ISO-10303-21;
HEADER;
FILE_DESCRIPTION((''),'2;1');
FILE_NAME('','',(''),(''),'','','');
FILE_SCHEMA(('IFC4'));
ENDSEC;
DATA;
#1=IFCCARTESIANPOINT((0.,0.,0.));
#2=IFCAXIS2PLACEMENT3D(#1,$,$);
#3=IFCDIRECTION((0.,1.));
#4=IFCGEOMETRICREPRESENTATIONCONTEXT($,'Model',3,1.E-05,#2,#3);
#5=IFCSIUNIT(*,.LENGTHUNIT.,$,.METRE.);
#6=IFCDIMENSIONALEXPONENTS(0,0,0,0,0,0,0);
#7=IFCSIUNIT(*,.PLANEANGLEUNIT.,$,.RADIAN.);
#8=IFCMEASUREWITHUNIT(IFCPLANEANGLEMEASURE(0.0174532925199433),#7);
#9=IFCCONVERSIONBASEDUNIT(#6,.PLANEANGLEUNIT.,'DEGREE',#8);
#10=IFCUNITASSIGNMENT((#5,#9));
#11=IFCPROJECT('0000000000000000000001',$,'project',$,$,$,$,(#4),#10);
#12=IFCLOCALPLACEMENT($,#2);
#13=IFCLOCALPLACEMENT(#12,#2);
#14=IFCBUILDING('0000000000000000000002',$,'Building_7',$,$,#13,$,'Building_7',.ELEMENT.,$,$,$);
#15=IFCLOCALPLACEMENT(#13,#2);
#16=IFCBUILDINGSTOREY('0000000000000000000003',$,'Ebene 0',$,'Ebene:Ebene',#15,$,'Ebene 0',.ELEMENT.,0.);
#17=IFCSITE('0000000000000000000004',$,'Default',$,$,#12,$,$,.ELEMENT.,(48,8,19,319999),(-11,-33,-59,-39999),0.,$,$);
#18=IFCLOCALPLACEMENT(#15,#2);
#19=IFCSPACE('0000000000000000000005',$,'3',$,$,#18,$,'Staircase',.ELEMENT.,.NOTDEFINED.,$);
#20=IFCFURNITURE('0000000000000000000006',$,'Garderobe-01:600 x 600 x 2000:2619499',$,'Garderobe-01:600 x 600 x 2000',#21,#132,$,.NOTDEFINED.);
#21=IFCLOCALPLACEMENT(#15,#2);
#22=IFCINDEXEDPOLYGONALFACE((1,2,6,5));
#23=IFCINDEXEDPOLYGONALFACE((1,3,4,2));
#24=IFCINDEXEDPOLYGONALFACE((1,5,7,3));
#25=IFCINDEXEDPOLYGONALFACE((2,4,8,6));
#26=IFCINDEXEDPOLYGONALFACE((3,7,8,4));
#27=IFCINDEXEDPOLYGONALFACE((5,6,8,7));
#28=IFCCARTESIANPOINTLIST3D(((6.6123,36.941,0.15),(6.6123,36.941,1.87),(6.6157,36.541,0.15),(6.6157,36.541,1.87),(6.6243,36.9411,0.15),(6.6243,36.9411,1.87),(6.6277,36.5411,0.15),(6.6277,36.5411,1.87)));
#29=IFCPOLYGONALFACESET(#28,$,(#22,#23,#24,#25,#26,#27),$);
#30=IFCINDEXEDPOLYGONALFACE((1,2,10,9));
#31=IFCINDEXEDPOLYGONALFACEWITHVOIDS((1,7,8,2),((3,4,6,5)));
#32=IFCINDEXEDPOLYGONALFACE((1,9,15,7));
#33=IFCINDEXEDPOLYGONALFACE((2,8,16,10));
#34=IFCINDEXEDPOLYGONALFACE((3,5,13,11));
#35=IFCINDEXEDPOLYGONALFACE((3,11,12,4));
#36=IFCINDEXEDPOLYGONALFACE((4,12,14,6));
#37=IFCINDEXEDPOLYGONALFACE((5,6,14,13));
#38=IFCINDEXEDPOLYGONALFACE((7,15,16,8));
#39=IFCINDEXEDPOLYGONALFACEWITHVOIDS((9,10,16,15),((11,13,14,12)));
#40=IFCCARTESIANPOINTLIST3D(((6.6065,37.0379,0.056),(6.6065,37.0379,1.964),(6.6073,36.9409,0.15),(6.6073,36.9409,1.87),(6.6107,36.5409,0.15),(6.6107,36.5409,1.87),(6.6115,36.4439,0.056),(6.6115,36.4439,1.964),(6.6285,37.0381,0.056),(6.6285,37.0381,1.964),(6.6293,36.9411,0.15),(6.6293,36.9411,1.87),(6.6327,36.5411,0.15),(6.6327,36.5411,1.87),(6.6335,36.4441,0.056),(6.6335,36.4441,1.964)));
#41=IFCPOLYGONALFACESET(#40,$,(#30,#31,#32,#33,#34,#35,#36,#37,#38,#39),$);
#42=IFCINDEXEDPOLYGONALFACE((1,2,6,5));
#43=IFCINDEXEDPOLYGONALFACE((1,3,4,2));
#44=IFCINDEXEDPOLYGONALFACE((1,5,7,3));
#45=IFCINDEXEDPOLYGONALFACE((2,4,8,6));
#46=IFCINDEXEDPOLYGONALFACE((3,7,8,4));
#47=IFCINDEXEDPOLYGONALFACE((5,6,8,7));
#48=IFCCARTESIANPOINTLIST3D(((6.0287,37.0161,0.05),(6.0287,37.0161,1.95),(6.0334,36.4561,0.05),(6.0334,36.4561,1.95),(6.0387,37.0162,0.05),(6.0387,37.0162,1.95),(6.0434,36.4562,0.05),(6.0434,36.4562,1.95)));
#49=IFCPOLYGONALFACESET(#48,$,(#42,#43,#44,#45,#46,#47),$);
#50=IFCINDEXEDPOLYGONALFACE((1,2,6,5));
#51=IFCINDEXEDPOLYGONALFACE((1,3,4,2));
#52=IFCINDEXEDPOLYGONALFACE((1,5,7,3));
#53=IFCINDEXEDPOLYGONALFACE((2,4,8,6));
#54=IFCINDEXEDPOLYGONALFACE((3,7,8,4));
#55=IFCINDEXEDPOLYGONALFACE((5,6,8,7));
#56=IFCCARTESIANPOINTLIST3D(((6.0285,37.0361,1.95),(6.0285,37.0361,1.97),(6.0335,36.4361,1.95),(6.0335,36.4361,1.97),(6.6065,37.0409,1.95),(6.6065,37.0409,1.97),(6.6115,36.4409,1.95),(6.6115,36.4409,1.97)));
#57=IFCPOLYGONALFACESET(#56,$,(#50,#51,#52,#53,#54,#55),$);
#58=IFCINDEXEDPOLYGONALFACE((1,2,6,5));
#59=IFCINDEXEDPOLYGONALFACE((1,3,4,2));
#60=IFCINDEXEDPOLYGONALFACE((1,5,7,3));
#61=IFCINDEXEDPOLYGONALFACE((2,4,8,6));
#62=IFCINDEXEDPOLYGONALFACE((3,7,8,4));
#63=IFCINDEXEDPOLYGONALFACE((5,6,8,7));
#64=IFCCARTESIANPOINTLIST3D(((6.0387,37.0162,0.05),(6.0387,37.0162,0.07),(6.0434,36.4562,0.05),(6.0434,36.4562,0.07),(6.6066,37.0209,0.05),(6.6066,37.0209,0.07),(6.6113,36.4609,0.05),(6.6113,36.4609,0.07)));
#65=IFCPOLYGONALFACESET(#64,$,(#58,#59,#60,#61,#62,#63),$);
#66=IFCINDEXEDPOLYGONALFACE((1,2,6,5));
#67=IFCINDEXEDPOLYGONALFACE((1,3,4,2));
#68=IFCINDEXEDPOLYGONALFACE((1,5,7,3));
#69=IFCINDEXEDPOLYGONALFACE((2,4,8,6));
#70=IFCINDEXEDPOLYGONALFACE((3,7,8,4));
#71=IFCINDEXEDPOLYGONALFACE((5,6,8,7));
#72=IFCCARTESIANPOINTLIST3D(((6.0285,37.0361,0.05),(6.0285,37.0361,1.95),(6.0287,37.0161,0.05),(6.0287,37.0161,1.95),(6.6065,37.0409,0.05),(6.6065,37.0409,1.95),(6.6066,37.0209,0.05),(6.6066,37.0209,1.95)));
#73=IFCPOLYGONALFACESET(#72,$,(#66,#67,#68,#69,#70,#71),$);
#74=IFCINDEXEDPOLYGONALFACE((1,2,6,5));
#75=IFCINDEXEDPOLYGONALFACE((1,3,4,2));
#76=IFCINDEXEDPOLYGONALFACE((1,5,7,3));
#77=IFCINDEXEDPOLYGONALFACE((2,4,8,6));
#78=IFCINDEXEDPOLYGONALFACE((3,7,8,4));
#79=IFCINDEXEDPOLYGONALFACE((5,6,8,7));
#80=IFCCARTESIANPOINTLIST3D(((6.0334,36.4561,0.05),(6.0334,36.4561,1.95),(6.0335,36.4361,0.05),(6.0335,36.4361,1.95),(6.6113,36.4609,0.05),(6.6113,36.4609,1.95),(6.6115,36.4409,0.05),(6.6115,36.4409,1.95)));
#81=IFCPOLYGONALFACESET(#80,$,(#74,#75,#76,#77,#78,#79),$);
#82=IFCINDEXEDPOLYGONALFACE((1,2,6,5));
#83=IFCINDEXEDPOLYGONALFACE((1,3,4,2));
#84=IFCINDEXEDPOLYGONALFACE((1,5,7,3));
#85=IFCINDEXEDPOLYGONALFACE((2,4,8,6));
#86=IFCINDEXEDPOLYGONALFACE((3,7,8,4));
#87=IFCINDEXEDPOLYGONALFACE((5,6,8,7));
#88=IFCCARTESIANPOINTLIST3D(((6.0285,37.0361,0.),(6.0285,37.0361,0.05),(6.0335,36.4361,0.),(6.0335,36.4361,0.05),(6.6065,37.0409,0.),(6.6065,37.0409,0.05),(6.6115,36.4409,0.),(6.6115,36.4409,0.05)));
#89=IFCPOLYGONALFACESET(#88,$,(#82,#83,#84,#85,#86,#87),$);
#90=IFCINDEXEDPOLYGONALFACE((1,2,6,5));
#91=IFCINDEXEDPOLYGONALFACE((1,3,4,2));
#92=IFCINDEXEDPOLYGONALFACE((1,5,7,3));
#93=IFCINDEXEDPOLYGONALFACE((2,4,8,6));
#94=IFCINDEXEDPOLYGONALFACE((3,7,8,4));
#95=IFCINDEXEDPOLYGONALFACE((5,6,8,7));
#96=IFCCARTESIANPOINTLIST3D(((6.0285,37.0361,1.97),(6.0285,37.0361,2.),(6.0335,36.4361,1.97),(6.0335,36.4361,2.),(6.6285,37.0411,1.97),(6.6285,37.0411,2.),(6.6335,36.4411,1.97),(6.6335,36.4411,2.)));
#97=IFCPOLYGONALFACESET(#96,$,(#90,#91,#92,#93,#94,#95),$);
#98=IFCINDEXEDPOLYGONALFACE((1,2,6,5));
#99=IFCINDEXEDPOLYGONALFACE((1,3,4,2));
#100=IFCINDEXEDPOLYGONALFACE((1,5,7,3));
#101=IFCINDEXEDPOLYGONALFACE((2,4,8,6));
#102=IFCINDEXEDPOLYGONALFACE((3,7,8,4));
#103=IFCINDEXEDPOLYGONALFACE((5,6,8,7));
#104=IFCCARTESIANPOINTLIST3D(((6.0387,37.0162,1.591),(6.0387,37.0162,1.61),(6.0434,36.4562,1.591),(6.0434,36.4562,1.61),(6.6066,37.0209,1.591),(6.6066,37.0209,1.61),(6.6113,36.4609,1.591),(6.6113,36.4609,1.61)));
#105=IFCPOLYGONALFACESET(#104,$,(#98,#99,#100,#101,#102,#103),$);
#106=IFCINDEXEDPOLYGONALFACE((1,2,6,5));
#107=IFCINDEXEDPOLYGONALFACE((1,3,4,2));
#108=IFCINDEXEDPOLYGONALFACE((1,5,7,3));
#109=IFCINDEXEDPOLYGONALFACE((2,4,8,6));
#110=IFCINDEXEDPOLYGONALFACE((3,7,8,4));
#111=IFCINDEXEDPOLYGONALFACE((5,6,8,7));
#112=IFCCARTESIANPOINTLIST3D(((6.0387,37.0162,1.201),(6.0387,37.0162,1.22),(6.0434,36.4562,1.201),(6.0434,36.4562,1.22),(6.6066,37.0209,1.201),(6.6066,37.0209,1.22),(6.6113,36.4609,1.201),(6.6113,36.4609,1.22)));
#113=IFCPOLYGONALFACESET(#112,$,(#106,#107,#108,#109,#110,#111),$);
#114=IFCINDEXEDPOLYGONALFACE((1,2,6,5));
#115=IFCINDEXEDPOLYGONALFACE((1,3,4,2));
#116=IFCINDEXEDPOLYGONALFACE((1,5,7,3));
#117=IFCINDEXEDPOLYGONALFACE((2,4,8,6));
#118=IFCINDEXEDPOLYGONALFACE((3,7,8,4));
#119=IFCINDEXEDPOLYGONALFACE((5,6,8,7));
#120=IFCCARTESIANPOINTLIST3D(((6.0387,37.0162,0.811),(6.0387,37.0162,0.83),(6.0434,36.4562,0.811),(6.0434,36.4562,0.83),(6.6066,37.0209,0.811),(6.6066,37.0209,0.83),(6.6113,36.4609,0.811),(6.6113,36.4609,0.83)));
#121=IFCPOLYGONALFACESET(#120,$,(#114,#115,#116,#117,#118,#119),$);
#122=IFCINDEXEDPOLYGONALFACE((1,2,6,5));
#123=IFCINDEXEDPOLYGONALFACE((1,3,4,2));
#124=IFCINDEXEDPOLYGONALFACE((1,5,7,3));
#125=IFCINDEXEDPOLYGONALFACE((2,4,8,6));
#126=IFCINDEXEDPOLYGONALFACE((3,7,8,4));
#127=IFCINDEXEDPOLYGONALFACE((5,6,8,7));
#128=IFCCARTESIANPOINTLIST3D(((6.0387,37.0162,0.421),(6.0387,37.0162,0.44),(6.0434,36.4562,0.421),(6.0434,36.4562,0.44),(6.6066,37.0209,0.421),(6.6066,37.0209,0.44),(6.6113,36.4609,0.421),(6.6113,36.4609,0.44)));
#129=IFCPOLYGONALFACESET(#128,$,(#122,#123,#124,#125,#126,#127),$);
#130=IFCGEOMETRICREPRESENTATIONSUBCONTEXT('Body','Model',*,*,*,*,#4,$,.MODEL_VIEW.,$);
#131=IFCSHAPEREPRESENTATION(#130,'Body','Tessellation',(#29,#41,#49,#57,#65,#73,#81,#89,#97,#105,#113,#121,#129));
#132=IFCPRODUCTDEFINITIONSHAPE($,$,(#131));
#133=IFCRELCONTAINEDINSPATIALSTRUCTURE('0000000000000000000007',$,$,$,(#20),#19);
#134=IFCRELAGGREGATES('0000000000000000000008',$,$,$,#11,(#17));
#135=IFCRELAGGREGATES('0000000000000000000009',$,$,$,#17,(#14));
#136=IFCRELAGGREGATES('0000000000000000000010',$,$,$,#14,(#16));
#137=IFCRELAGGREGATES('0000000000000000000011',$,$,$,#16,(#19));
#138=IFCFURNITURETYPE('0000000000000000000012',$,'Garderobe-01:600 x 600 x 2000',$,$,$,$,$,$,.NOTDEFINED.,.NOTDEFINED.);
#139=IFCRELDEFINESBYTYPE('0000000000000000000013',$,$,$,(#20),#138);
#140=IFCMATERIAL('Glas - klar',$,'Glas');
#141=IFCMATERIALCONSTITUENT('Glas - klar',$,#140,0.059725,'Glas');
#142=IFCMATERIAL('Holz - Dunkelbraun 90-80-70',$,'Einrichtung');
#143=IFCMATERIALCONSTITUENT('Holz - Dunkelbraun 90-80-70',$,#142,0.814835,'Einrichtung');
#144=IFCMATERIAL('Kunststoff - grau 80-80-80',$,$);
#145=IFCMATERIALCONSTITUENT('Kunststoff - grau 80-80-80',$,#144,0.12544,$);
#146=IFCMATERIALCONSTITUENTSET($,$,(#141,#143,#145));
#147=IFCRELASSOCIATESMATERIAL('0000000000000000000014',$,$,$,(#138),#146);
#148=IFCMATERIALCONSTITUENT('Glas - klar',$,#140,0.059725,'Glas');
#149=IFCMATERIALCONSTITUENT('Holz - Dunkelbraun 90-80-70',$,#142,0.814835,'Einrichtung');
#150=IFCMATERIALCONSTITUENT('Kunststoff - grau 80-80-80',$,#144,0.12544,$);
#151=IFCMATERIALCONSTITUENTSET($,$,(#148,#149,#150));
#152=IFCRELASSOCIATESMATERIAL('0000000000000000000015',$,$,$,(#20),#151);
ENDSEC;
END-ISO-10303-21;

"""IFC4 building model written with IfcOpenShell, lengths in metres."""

from ifc_helpers import new_model, entity, si_unit, converted_unit, direction, frame, origin, place, context, subcontext, project, spatial, indexed_curve, outline, extrude, source, transform, mapped, material, constituent, constituent_set, type_object, type_shapes, element, save


model = new_model("IFC4")

# Units and contexts
model_context = context("Model", 3, precision=1e-05, world=origin(), true_north=direction((0.0, 1.0)))
body_context = subcontext(model_context, "Body", "Model", "MODEL_VIEW")
ifc_project = project(units=[si_unit("LENGTHUNIT", "METRE"), converted_unit("PLANEANGLEUNIT", "DEGREE", entity("IfcPlaneAngleMeasure", 0.0174532925199433), si_unit("PLANEANGLEUNIT", "RADIAN"), dimensions=[0, 0, 0, 0, 0, 0, 0])], contexts=[model_context])

# Site, building, storey
site_placement = place(None, origin())
site = spatial("IfcSite", under=ifc_project, at=site_placement, Name="Default", CompositionType="ELEMENT", RefLatitude=(48, 8, 19, 319999), RefLongitude=(-11, -33, -59, -39999), RefElevation=0.0)
building_placement = place(site_placement, origin())
building = spatial("IfcBuilding", under=site, at=building_placement, Name="Building_7", LongName="Building_7", CompositionType="ELEMENT")
storey_placement = place(building_placement, origin())
storey = spatial("IfcBuildingStorey", under=building, at=storey_placement, Name="Ebene 0", ObjectType="Ebene:Ebene", LongName="Ebene 0", CompositionType="ELEMENT", Elevation=0.0)

# Shared definitions
ifc_material_1 = material(Name="Glas - klar", Category="Glas")
ifc_material_2 = material(Name="Holz - Dunkelbraun 90-80-70", Category="Einrichtung")
ifc_material_3 = material(Name="Kunststoff - grau 80-80-80")
ifc_constituent_1 = constituent(ifc_material_1, Name="Glas - klar", Category="Glas", fraction=0.059725)
ifc_constituent_2 = constituent(ifc_material_2, Name="Holz - Dunkelbraun 90-80-70", Category="Einrichtung", fraction=0.814835)
ifc_constituent_3 = constituent(ifc_material_3, Name="Kunststoff - grau 80-80-80", fraction=0.12544)
ifc_constituent_set_1 = constituent_set(constituents=[ifc_constituent_1, ifc_constituent_2, ifc_constituent_3])
furniture_type_1 = type_object("IfcFurnitureType", Name="Garderobe-01:600 x 600 x 2000", AssemblyPlace="NOTDEFINED", PredefinedType="NOTDEFINED", material=ifc_constituent_set_1)
shared_shape_1 = source(origin(), body_context, "Body", "SweptSolid", [
    extrude(outline(indexed_curve([(-0.006, -0.2), (0.006, -0.2), (0.006, 0.2), (-0.006, 0.2), (-0.006, -0.2)], self_intersect=False)), frame((0.0, -0.289, 0.15), z_axis=(0.0, 0.0, 1.0), x_axis=(0.0, 1.0, 0.0)), (0.0, 0.0, 1.0), 1.72),
    extrude(outline(indexed_curve([(-0.954, -0.297), (0.954, -0.297), (0.954, 0.297), (-0.954, 0.297), (-0.954, -0.297)], self_intersect=False), holes=[indexed_curve([(-0.86, 0.2), (0.86, 0.2), (0.86, -0.2), (-0.86, -0.2), (-0.86, 0.2)], self_intersect=False)]), frame((0.0, -0.3, 1.01), z_axis=(0.0, 1.0, 0.0), x_axis=(0.0, 0.0, -1.0)), (0.0, 0.0, 1.0), 0.022),
    extrude(outline(indexed_curve([(-0.28, -0.005), (0.28, -0.005), (0.28, 0.005), (-0.28, 0.005), (-0.28, -0.005)], self_intersect=False)), frame((0.0, 0.295, 0.05), z_axis=(0.0, 0.0, 1.0), x_axis=(-1.0, 0.0, 0.0)), (0.0, 0.0, 1.0), 1.9),
    extrude(outline(indexed_curve([(-0.3, -0.289), (0.3, -0.289), (0.3, 0.289), (-0.3, 0.289), (-0.3, -0.289)], self_intersect=False)), frame((0.0, 0.011, 1.95), z_axis=(0.0, 0.0, 1.0), x_axis=(-1.0, 0.0, 0.0)), (0.0, 0.0, 1.0), 0.02),
    extrude(outline(indexed_curve([(-0.28, -0.284), (0.28, -0.284), (0.28, 0.284), (-0.28, 0.284), (-0.28, -0.284)], self_intersect=False)), frame((0.0, 0.006, 0.05), z_axis=(0.0, 0.0, 1.0), x_axis=(-1.0, 0.0, 0.0)), (0.0, 0.0, 1.0), 0.02),
    extrude(outline(indexed_curve([(-0.01, -0.289), (0.01, -0.289), (0.01, 0.289), (-0.01, 0.289), (-0.01, -0.289)], self_intersect=False)), frame((0.29, 0.011, 0.05), z_axis=(0.0, 0.0, 1.0), x_axis=(-1.0, 0.0, 0.0)), (0.0, 0.0, 1.0), 1.9),
    extrude(outline(indexed_curve([(-0.01, -0.289), (0.01, -0.289), (0.01, 0.289), (-0.01, 0.289), (-0.01, -0.289)], self_intersect=False)), frame((-0.29, 0.011, 0.05), z_axis=(0.0, 0.0, 1.0), x_axis=(-1.0, 0.0, 0.0)), (0.0, 0.0, 1.0), 1.9),
    extrude(outline(indexed_curve([(-0.3, -0.289), (0.3, -0.289), (0.3, 0.289), (-0.3, 0.289), (-0.3, -0.289)], self_intersect=False)), frame((0.0, 0.011, 0.0), z_axis=(0.0, 0.0, 1.0), x_axis=(-1.0, 0.0, 0.0)), (0.0, 0.0, 1.0), 0.05),
    extrude(outline(indexed_curve([(-0.3, -0.3), (0.3, -0.3), (0.3, 0.3), (-0.3, 0.3), (-0.3, -0.3)], self_intersect=False)), frame((0.0, 0.0, 1.97), z_axis=(0.0, 0.0, 1.0), x_axis=(-1.0, 0.0, 0.0)), (0.0, 0.0, 1.0), 0.03),
    extrude(outline(indexed_curve([(-0.28, -0.284), (0.28, -0.284), (0.28, 0.284), (-0.28, 0.284), (-0.28, -0.284)], self_intersect=False)), frame((0.0, 0.006, 1.591), z_axis=(0.0, 0.0, 1.0), x_axis=(-1.0, 0.0, 0.0)), (0.0, 0.0, 1.0), 0.019),
    extrude(outline(indexed_curve([(-0.28, -0.284), (0.28, -0.284), (0.28, 0.284), (-0.28, 0.284), (-0.28, -0.284)], self_intersect=False)), frame((0.0, 0.006, 1.201), z_axis=(0.0, 0.0, 1.0), x_axis=(-1.0, 0.0, 0.0)), (0.0, 0.0, 1.0), 0.019),
    extrude(outline(indexed_curve([(-0.28, -0.284), (0.28, -0.284), (0.28, 0.284), (-0.28, 0.284), (-0.28, -0.284)], self_intersect=False)), frame((0.0, 0.006, 0.811), z_axis=(0.0, 0.0, 1.0), x_axis=(-1.0, 0.0, 0.0)), (0.0, 0.0, 1.0), 0.019),
    extrude(outline(indexed_curve([(-0.28, -0.284), (0.28, -0.284), (0.28, 0.284), (-0.28, 0.284), (-0.28, -0.284)], self_intersect=False)), frame((0.0, 0.006, 0.421), z_axis=(0.0, 0.0, 1.0), x_axis=(-1.0, 0.0, 0.0)), (0.0, 0.0, 1.0), 0.019),
])
type_shapes(furniture_type_1, [shared_shape_1])

# Shared definitions
space_1_placement = place(storey_placement, origin())
space_1 = spatial("IfcSpace", under=storey, at=space_1_placement, Name="3", LongName="Staircase", CompositionType="ELEMENT", PredefinedType="NOTDEFINED")

# Furniture
ifc_constituent_4 = constituent(ifc_material_1, Name="Glas - klar", Category="Glas", fraction=0.059725)
ifc_constituent_5 = constituent(ifc_material_2, Name="Holz - Dunkelbraun 90-80-70", Category="Einrichtung", fraction=0.814835)
ifc_constituent_6 = constituent(ifc_material_3, Name="Kunststoff - grau 80-80-80", fraction=0.12544)
ifc_constituent_set_2 = constituent_set(constituents=[ifc_constituent_4, ifc_constituent_5, ifc_constituent_6])
furniture_1_placement = place(space_1_placement, frame((6.331, 36.7386, 0.0), z_axis=(0.0, 0.0, 1.0), x_axis=(-0.008366, 0.999965, 0.0)))
element("IfcFurniture", 1, at=furniture_1_placement, inside=space_1, type_object=furniture_type_1, material=ifc_constituent_set_2, Name="Garderobe-01:600 x 600 x 2000:2619499", ObjectType="Garderobe-01:600 x 600 x 2000", PredefinedType="NOTDEFINED", context=body_context, shape_type="MappedRepresentation", body=[
    mapped(shared_shape_1, transform((0.0, 0.0, 0.0), scale=1.0)),
])

save(model, "model.ifc")
